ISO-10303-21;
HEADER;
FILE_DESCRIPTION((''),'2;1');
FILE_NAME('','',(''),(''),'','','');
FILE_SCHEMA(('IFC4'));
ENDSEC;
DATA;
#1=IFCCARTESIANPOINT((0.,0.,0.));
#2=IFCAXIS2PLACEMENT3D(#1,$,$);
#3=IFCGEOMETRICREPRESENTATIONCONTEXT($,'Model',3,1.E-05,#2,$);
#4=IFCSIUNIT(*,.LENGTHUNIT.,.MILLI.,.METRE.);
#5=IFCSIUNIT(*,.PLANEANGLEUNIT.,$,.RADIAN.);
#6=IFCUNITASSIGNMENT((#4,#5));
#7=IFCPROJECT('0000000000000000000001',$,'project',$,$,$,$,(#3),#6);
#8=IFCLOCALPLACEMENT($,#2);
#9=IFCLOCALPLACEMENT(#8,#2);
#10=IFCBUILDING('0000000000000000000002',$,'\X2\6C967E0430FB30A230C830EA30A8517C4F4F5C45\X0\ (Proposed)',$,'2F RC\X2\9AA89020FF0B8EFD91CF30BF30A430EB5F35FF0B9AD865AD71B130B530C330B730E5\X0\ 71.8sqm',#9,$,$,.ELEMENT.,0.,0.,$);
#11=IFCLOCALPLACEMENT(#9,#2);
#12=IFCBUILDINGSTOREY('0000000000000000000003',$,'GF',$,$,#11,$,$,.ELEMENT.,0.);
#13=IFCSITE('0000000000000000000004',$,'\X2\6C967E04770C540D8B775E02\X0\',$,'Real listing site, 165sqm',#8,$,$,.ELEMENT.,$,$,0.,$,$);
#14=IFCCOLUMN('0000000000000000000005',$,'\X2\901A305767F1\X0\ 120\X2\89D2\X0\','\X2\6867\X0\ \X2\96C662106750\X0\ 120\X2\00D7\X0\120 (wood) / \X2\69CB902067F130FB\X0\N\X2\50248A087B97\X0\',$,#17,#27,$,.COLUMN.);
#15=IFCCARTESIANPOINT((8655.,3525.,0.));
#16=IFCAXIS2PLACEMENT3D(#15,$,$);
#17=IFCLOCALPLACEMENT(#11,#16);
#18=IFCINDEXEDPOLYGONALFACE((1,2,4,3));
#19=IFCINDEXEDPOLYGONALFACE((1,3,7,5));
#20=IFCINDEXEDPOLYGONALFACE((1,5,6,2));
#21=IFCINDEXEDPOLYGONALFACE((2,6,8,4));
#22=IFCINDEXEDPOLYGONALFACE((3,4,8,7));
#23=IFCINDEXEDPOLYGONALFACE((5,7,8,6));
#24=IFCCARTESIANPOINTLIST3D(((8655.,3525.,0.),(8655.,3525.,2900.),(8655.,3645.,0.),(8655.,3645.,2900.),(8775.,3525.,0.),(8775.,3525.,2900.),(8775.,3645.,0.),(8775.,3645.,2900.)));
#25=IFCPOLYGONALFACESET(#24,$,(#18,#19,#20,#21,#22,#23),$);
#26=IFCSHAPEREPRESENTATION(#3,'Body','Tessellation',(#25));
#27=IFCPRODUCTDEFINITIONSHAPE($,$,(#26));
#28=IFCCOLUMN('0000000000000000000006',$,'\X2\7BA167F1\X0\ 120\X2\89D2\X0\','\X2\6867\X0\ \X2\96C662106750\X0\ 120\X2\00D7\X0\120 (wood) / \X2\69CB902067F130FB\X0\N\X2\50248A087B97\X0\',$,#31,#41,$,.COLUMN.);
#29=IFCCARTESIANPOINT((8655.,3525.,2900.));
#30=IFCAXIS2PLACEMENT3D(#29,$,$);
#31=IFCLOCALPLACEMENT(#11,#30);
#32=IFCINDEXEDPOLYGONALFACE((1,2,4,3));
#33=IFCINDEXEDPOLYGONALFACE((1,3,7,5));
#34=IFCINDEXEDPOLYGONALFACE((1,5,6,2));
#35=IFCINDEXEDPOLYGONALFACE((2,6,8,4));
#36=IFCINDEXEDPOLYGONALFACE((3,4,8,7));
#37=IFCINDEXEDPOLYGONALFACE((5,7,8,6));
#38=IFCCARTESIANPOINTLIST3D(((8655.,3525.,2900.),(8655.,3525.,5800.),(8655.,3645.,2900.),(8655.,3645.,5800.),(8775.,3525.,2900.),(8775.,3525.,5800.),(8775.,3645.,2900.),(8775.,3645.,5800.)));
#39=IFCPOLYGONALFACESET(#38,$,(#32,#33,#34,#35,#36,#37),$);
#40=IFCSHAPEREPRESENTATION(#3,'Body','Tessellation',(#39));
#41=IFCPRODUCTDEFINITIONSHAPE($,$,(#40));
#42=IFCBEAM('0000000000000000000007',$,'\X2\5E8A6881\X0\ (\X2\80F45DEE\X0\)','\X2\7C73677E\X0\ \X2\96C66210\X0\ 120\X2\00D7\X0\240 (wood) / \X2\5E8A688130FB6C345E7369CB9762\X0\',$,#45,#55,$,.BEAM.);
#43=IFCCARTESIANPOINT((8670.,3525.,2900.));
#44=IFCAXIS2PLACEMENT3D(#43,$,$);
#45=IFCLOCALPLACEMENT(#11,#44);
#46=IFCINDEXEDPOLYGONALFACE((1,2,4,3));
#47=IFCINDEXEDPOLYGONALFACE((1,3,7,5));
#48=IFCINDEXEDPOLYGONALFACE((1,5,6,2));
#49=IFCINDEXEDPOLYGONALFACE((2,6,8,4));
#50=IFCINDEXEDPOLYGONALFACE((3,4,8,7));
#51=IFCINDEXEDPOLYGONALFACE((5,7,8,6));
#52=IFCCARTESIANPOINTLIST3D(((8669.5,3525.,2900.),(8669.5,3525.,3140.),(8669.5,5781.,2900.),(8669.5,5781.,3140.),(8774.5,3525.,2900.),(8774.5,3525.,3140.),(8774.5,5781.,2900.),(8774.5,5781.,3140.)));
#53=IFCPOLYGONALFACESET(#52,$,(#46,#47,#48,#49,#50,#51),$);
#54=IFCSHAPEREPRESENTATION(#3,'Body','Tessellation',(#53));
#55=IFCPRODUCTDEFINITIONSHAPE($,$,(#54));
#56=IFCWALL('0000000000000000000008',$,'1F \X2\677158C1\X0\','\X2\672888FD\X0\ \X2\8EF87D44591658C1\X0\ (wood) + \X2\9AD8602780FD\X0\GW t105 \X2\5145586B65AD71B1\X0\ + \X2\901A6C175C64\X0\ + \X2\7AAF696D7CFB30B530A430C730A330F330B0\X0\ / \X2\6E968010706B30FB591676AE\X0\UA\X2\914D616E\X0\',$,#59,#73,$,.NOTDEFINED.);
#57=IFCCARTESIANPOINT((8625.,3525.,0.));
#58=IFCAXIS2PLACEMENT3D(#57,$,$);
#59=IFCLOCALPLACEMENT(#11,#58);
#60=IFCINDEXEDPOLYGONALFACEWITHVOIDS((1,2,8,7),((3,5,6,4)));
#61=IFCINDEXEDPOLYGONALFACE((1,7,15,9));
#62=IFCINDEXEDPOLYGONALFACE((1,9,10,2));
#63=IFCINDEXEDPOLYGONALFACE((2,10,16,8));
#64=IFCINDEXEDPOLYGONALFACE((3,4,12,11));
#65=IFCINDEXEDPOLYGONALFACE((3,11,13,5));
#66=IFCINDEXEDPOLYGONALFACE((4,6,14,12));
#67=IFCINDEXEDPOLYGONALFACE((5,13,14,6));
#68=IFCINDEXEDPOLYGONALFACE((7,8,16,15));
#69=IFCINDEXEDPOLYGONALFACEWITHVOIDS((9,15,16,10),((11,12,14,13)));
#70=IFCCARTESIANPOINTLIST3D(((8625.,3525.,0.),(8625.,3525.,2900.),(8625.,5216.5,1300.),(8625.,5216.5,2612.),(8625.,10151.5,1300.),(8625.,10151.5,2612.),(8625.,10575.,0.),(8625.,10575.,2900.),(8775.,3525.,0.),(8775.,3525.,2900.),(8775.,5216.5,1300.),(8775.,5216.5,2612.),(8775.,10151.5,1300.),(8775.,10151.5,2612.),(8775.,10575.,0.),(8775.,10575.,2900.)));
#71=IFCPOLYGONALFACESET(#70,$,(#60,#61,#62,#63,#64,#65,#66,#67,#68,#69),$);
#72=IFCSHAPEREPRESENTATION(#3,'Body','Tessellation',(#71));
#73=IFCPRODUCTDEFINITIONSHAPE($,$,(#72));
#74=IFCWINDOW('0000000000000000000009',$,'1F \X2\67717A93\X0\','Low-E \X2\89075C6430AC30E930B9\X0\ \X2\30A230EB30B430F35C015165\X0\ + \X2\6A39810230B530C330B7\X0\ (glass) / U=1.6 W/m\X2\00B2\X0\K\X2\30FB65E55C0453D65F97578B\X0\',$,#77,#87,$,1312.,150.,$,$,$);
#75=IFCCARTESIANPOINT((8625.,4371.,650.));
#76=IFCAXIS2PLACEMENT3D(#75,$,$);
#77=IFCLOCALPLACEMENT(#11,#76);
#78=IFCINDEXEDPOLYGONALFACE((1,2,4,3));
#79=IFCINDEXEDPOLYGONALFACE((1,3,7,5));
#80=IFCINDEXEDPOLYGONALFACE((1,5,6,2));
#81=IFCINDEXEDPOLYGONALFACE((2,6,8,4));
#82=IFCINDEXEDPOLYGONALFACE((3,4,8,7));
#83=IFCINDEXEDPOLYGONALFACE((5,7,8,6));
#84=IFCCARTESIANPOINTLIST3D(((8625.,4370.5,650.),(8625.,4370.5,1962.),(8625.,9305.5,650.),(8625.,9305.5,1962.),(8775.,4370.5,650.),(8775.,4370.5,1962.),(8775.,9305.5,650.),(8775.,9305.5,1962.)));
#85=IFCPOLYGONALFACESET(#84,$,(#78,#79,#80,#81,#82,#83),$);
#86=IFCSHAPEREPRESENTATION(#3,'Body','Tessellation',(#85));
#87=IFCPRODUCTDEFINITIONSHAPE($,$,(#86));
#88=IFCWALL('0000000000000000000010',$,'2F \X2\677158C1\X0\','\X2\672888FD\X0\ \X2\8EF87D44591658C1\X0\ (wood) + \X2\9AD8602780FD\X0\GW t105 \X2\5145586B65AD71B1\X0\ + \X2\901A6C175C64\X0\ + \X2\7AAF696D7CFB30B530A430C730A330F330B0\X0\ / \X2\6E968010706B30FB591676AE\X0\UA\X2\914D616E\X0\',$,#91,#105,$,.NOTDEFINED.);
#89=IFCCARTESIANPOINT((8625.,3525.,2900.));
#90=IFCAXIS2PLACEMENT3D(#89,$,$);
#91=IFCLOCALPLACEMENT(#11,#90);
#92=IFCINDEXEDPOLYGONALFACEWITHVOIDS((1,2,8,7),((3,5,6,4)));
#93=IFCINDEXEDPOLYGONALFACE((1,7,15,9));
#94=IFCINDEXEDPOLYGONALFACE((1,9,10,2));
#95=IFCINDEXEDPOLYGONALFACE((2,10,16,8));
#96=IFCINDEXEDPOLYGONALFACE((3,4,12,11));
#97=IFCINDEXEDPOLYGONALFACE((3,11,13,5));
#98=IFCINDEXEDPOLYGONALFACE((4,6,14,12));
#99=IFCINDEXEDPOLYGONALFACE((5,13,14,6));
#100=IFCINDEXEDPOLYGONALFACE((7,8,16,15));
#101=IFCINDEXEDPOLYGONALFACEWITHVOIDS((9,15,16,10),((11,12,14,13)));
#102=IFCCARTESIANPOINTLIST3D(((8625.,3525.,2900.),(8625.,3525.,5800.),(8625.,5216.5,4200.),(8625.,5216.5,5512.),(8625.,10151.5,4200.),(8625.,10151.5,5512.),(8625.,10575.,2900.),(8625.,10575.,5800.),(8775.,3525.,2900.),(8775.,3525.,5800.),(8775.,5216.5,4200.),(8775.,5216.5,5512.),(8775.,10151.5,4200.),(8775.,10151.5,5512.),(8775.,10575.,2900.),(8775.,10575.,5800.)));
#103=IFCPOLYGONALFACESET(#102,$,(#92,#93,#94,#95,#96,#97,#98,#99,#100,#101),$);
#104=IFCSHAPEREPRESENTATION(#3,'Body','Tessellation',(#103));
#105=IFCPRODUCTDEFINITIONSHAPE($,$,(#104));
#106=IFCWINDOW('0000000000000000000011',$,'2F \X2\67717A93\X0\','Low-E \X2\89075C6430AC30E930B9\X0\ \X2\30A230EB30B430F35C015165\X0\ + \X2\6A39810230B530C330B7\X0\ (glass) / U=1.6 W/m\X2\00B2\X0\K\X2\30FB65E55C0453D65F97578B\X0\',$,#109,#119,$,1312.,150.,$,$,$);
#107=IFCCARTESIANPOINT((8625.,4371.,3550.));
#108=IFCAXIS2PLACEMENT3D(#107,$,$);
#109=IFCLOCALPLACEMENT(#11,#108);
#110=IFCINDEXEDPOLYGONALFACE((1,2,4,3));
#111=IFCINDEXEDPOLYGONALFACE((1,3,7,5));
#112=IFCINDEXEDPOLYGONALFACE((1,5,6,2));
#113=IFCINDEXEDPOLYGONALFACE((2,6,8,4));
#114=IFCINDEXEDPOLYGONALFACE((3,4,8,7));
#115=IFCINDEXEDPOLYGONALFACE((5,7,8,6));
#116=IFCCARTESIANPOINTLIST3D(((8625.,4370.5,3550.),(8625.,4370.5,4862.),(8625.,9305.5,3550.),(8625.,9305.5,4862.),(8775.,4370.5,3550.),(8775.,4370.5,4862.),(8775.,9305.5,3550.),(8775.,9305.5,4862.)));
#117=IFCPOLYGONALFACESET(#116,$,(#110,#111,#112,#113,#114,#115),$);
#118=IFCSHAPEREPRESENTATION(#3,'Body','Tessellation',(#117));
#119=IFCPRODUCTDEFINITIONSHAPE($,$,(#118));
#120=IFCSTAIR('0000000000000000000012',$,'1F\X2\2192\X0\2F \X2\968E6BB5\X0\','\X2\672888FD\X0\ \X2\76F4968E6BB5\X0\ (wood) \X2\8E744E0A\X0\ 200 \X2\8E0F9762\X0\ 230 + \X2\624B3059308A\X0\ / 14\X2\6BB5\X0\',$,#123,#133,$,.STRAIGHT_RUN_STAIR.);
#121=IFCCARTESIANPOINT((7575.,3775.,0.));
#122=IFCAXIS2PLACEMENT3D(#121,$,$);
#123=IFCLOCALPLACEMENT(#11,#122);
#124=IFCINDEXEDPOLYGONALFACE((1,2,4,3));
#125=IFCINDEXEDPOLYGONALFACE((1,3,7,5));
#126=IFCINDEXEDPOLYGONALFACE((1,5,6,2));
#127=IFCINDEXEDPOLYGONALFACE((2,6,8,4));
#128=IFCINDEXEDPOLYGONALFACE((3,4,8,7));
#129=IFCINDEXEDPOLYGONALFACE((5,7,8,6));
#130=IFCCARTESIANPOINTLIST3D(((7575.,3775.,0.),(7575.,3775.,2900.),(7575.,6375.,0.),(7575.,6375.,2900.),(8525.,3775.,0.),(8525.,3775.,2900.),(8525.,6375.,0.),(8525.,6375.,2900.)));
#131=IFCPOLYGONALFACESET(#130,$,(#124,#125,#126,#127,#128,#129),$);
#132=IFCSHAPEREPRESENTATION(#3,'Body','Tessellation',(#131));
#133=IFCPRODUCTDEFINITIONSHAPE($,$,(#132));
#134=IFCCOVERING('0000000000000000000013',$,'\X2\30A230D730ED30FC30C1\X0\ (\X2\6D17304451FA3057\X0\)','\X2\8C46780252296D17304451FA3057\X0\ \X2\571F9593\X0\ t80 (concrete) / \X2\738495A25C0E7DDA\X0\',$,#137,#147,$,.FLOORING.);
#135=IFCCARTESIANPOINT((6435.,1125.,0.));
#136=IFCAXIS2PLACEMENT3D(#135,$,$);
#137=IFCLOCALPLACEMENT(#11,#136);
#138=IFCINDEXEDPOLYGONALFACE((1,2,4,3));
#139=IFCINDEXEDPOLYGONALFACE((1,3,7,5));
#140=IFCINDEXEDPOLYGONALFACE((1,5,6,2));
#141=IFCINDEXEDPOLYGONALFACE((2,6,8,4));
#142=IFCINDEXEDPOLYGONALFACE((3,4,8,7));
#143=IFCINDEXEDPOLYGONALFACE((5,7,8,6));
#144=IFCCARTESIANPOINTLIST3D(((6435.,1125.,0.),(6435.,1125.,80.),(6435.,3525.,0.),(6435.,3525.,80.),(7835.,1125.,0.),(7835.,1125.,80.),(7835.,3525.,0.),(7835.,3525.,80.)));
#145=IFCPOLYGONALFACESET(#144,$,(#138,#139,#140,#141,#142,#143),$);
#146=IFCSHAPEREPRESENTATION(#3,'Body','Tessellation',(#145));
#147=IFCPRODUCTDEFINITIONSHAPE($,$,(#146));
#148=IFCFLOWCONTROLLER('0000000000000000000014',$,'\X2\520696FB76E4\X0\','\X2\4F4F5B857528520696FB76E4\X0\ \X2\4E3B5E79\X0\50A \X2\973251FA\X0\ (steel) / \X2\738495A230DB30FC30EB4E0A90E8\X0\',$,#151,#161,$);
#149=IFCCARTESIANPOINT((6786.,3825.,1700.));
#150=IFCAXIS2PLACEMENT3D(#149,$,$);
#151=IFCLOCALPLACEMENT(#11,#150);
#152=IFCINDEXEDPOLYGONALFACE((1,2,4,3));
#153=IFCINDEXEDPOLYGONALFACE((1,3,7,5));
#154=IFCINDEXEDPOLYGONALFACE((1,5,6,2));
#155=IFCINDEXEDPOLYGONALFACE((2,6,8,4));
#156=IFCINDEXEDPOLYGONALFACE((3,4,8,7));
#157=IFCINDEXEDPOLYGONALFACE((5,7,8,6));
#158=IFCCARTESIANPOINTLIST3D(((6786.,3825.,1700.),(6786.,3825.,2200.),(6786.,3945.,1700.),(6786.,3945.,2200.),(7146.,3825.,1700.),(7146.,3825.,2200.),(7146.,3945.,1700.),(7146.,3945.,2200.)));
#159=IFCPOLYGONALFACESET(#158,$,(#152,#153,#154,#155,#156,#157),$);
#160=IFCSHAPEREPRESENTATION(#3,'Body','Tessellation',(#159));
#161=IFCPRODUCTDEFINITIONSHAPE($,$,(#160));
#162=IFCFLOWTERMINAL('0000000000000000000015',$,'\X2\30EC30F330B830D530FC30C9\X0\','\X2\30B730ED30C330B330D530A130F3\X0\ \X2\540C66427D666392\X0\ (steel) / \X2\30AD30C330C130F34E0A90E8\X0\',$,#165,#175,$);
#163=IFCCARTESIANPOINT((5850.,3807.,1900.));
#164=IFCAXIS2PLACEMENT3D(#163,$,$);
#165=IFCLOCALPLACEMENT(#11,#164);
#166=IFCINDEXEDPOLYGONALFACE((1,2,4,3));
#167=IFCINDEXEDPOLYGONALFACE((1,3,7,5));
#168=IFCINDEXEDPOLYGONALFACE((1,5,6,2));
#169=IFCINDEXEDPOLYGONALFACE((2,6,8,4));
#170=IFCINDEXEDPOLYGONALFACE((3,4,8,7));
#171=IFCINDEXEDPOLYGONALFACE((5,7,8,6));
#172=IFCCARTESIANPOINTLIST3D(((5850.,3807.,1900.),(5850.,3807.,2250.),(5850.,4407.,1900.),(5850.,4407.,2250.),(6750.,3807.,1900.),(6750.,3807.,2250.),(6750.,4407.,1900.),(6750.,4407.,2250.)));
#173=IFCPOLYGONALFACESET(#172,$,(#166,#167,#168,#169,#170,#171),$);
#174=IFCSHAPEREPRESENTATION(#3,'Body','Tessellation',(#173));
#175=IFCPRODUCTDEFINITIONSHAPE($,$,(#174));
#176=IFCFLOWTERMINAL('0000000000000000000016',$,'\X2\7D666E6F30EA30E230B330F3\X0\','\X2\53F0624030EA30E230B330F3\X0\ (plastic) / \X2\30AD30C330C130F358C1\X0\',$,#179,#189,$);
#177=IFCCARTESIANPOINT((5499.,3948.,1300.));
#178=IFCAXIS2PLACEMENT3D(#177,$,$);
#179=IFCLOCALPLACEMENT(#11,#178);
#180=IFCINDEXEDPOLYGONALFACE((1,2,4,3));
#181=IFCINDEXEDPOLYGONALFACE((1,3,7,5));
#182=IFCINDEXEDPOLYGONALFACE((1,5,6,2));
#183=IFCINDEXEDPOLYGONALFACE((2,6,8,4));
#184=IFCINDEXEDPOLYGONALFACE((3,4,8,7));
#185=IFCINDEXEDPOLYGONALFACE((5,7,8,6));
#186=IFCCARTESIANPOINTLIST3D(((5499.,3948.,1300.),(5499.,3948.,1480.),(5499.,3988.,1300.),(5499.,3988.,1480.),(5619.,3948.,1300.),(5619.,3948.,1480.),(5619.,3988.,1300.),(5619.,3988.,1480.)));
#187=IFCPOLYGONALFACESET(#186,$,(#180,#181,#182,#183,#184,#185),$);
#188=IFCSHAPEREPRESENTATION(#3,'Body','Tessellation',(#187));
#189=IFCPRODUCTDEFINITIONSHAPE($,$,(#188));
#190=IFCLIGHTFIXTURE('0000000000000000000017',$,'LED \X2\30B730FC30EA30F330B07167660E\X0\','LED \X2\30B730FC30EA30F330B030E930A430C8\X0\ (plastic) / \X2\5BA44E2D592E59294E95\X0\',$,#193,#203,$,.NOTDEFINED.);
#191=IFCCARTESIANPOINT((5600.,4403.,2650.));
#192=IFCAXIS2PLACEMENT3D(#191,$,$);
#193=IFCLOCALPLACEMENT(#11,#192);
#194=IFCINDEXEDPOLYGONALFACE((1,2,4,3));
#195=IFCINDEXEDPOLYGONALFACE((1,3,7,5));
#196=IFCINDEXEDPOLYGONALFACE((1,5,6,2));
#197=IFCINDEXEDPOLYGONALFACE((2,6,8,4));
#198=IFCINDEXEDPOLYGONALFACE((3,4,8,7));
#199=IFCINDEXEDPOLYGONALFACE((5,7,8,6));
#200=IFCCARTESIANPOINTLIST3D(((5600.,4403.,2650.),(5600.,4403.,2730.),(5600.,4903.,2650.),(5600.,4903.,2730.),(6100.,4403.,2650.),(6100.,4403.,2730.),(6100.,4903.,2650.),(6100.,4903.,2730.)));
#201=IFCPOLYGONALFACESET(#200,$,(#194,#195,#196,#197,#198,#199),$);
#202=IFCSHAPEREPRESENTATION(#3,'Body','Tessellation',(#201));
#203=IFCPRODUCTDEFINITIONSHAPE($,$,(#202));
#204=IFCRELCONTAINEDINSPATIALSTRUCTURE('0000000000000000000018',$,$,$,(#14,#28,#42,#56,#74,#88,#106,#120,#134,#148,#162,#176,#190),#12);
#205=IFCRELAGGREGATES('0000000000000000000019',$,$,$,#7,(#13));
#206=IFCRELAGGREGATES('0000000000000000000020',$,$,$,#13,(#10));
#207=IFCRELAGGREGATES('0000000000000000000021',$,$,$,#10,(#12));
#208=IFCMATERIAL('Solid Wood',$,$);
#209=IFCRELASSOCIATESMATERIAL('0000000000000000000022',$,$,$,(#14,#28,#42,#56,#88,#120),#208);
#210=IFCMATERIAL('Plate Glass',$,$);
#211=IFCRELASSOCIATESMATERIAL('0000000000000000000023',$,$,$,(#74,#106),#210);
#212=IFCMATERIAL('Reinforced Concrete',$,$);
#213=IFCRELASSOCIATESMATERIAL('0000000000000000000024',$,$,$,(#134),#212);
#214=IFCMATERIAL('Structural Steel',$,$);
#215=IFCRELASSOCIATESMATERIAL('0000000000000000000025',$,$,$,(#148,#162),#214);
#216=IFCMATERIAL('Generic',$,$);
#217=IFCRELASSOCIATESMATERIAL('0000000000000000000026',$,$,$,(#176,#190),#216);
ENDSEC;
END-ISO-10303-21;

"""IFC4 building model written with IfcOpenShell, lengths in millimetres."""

from ifc_helpers import new_model, si_unit, frame, frame_2d, origin, place, context, project, spatial, rectangle, extrude, material, element, fill, save


model = new_model("IFC4")

# Units and contexts
model_context = context("Model", 3, precision=1e-05, world=origin())
ifc_project = project(units=[si_unit("LENGTHUNIT", "METRE", prefix="MILLI"), si_unit("PLANEANGLEUNIT", "RADIAN")], contexts=[model_context])

# Site, building, storey
site_placement = place(None, origin())
site = spatial("IfcSite", under=ifc_project, at=site_placement, Name="沖縄県名護市", ObjectType="Real listing site, 165sqm", CompositionType="ELEMENT", RefElevation=0.0)
building_placement = place(site_placement, origin())
building = spatial("IfcBuilding", under=site, at=building_placement, Name="沖縄・アトリエ兼住居 (Proposed)", ObjectType="2F RC骨造＋軽量タイル張＋高断熱サッシュ 71.8sqm", CompositionType="ELEMENT", ElevationOfRefHeight=0.0, ElevationOfTerrain=0.0)
storey_placement = place(building_placement, origin())
storey = spatial("IfcBuildingStorey", under=building, at=storey_placement, Name="GF", CompositionType="ELEMENT", Elevation=0.0)

# Columns
ifc_material_1 = material(Name="Solid Wood")
column_1_placement = place(storey_placement, frame((8655.0, 3525.0, 0.0)))
element("IfcColumn", 1, at=column_1_placement, inside=storey, material=ifc_material_1, Name="通し柱 120角", Description="桧 集成材 120×120 (wood) / 構造柱・N値計算", PredefinedType="COLUMN", context=model_context, shape_type="SweptSolid", body=[
    extrude(rectangle(XDim=120.0, YDim=120.0, at=frame_2d((60.0, 60.0))), frame((8655.0, 3525.0, 0.0)), (0.0, 0.0, 1.0), 2900.0),
])
column_2_placement = place(storey_placement, frame((8655.0, 3525.0, 2900.0)))
element("IfcColumn", 2, at=column_2_placement, inside=storey, material=ifc_material_1, Name="管柱 120角", Description="桧 集成材 120×120 (wood) / 構造柱・N値計算", PredefinedType="COLUMN", context=model_context, shape_type="SweptSolid", body=[
    extrude(rectangle(XDim=120.0, YDim=120.0, at=frame_2d((60.0, 60.0))), frame((8655.0, 3525.0, 2900.0)), (0.0, 0.0, 1.0), 2900.0),
])

# Beam
beam_1_placement = place(storey_placement, frame((8670.0, 3525.0, 2900.0)))
element("IfcBeam", 3, at=beam_1_placement, inside=storey, material=ifc_material_1, Name="床梁 (胴差)", Description="米松 集成 120×240 (wood) / 床梁・水平構面", PredefinedType="BEAM", context=model_context, shape_type="SweptSolid", body=[
    extrude(rectangle(XDim=105.0, YDim=2256.0, at=frame_2d((52.0, 1128.0))), frame((8670.0, 3525.0, 2900.0)), (0.0, 0.0, 1.0), 240.0),
])

# Wall, opening, window
wall_1_placement = place(storey_placement, frame((8625.0, 3525.0, 0.0)))
wall_1 = element("IfcWall", 4, at=wall_1_placement, inside=storey, material=ifc_material_1, Name="1F 東壁", Description="木製 軸組外壁 (wood) + 高性能GW t105 充填断熱 + 通気層 + 窯業系サイディング / 準耐火・外皮UA配慮", PredefinedType="NOTDEFINED", context=model_context, shape_type="SweptSolid", body=[
    extrude(rectangle(XDim=150.0, YDim=7050.0, at=frame_2d((75.0, 3525.0))), frame((8625.0, 3525.0, 0.0)), (0.0, 0.0, 1.0), 2900.0),
])
opening_1_placement = place(storey_placement, frame((8625.0, 4371.0, 650.0)))
opening_1 = element("IfcOpeningElement", 5, at=opening_1_placement, cuts=wall_1, PredefinedType="NOTDEFINED", context=model_context, shape_type="SweptSolid", body=[
    extrude(rectangle(XDim=150.0, YDim=4935.0, at=frame_2d((75.0, 2467.0))), frame((8625.0, 4371.0, 650.0)), (0.0, 0.0, 1.0), 1312.0),
])
ifc_material_2 = material(Name="Plate Glass")
window_1_placement = place(storey_placement, frame((8625.0, 4371.0, 650.0)))
window_1 = element("IfcWindow", 6, at=window_1_placement, inside=storey, material=ifc_material_2, Name="1F 東窓", Description="Low-E 複層ガラス アルゴン封入 + 樹脂サッシ (glass) / U=1.6 W/m²K・日射取得型", OverallHeight=1312.0, OverallWidth=150.0, context=model_context, shape_type="SweptSolid", body=[
    extrude(rectangle(XDim=150.0, YDim=4935.0, at=frame_2d((75.0, 2467.0))), frame((8625.0, 4371.0, 650.0)), (0.0, 0.0, 1.0), 1312.0),
])
fill(opening_1, window_1)

# Wall, opening, window
wall_2_placement = place(storey_placement, frame((8625.0, 3525.0, 2900.0)))
wall_2 = element("IfcWall", 7, at=wall_2_placement, inside=storey, material=ifc_material_1, Name="2F 東壁", Description="木製 軸組外壁 (wood) + 高性能GW t105 充填断熱 + 通気層 + 窯業系サイディング / 準耐火・外皮UA配慮", PredefinedType="NOTDEFINED", context=model_context, shape_type="SweptSolid", body=[
    extrude(rectangle(XDim=150.0, YDim=7050.0, at=frame_2d((75.0, 3525.0))), frame((8625.0, 3525.0, 2900.0)), (0.0, 0.0, 1.0), 2900.0),
])
opening_2_placement = place(storey_placement, frame((8625.0, 4371.0, 3550.0)))
opening_2 = element("IfcOpeningElement", 8, at=opening_2_placement, cuts=wall_2, PredefinedType="NOTDEFINED", context=model_context, shape_type="SweptSolid", body=[
    extrude(rectangle(XDim=150.0, YDim=4935.0, at=frame_2d((75.0, 2467.0))), frame((8625.0, 4371.0, 3550.0)), (0.0, 0.0, 1.0), 1312.0),
])
window_2_placement = place(storey_placement, frame((8625.0, 4371.0, 3550.0)))
window_2 = element("IfcWindow", 9, at=window_2_placement, inside=storey, material=ifc_material_2, Name="2F 東窓", Description="Low-E 複層ガラス アルゴン封入 + 樹脂サッシ (glass) / U=1.6 W/m²K・日射取得型", OverallHeight=1312.0, OverallWidth=150.0, context=model_context, shape_type="SweptSolid", body=[
    extrude(rectangle(XDim=150.0, YDim=4935.0, at=frame_2d((75.0, 2467.0))), frame((8625.0, 4371.0, 3550.0)), (0.0, 0.0, 1.0), 1312.0),
])
fill(opening_2, window_2)

# Stair
stair_placement = place(storey_placement, frame((7575.0, 3775.0, 0.0)))
element("IfcStair", 10, at=stair_placement, inside=storey, material=ifc_material_1, Name="1F→2F 階段", Description="木製 直階段 (wood) 蹴上 200 踏面 230 + 手すり / 14段", PredefinedType="STRAIGHT_RUN_STAIR", context=model_context, shape_type="SweptSolid", body=[
    extrude(rectangle(XDim=950.0, YDim=2600.0, at=frame_2d((475.0, 1300.0))), frame((7575.0, 3775.0, 0.0)), (0.0, 0.0, 1.0), 2900.0),
])

# Covering
ifc_material_3 = material(Name="Reinforced Concrete")
covering_placement = place(storey_placement, frame((6435.0, 1125.0, 0.0)))
element("IfcCovering", 11, at=covering_placement, inside=storey, material=ifc_material_3, Name="アプローチ (洗い出し)", Description="豆砂利洗い出し 土間 t80 (concrete) / 玄関導線", PredefinedType="FLOORING", context=model_context, shape_type="SweptSolid", body=[
    extrude(rectangle(XDim=1400.0, YDim=2400.0, at=frame_2d((700.0, 1200.0))), frame((6435.0, 1125.0, 0.0)), (0.0, 0.0, 1.0), 80.0),
])

# Flow controller
ifc_material_4 = material(Name="Structural Steel")
flow_controller_placement = place(storey_placement, frame((6786.0, 3825.0, 1700.0)))
element("IfcFlowController", 12, at=flow_controller_placement, inside=storey, material=ifc_material_4, Name="分電盤", Description="住宅用分電盤 主幹50A 露出 (steel) / 玄関ホール上部", context=model_context, shape_type="SweptSolid", body=[
    extrude(rectangle(XDim=360.0, YDim=120.0, at=frame_2d((180.0, 60.0))), frame((6786.0, 3825.0, 1700.0)), (0.0, 0.0, 1.0), 500.0),
])

# Flow terminals
flow_terminal_1_placement = place(storey_placement, frame((5850.0, 3807.0, 1900.0)))
element("IfcFlowTerminal", 13, at=flow_terminal_1_placement, inside=storey, material=ifc_material_4, Name="レンジフード", Description="シロッコファン 同時給排 (steel) / キッチン上部", context=model_context, shape_type="SweptSolid", body=[
    extrude(rectangle(XDim=900.0, YDim=600.0, at=frame_2d((450.0, 300.0))), frame((5850.0, 3807.0, 1900.0)), (0.0, 0.0, 1.0), 350.0),
])
ifc_material_5 = material(Name="Generic")
flow_terminal_2_placement = place(storey_placement, frame((5499.0, 3948.0, 1300.0)))
element("IfcFlowTerminal", 14, at=flow_terminal_2_placement, inside=storey, material=ifc_material_5, Name="給湯リモコン", Description="台所リモコン (plastic) / キッチン壁", context=model_context, shape_type="SweptSolid", body=[
    extrude(rectangle(XDim=120.0, YDim=40.0, at=frame_2d((60.0, 20.0))), frame((5499.0, 3948.0, 1300.0)), (0.0, 0.0, 1.0), 180.0),
])

# Light fixture
light_fixture_1_placement = place(storey_placement, frame((5600.0, 4403.0, 2650.0)))
element("IfcLightFixture", 15, at=light_fixture_1_placement, inside=storey, material=ifc_material_5, Name="LED シーリング照明", Description="LED シーリングライト (plastic) / 室中央天井", PredefinedType="NOTDEFINED", context=model_context, shape_type="SweptSolid", body=[
    extrude(rectangle(XDim=500.0, YDim=500.0, at=frame_2d((250.0, 250.0))), frame((5600.0, 4403.0, 2650.0)), (0.0, 0.0, 1.0), 80.0),
])

save(model, "model.ifc")
